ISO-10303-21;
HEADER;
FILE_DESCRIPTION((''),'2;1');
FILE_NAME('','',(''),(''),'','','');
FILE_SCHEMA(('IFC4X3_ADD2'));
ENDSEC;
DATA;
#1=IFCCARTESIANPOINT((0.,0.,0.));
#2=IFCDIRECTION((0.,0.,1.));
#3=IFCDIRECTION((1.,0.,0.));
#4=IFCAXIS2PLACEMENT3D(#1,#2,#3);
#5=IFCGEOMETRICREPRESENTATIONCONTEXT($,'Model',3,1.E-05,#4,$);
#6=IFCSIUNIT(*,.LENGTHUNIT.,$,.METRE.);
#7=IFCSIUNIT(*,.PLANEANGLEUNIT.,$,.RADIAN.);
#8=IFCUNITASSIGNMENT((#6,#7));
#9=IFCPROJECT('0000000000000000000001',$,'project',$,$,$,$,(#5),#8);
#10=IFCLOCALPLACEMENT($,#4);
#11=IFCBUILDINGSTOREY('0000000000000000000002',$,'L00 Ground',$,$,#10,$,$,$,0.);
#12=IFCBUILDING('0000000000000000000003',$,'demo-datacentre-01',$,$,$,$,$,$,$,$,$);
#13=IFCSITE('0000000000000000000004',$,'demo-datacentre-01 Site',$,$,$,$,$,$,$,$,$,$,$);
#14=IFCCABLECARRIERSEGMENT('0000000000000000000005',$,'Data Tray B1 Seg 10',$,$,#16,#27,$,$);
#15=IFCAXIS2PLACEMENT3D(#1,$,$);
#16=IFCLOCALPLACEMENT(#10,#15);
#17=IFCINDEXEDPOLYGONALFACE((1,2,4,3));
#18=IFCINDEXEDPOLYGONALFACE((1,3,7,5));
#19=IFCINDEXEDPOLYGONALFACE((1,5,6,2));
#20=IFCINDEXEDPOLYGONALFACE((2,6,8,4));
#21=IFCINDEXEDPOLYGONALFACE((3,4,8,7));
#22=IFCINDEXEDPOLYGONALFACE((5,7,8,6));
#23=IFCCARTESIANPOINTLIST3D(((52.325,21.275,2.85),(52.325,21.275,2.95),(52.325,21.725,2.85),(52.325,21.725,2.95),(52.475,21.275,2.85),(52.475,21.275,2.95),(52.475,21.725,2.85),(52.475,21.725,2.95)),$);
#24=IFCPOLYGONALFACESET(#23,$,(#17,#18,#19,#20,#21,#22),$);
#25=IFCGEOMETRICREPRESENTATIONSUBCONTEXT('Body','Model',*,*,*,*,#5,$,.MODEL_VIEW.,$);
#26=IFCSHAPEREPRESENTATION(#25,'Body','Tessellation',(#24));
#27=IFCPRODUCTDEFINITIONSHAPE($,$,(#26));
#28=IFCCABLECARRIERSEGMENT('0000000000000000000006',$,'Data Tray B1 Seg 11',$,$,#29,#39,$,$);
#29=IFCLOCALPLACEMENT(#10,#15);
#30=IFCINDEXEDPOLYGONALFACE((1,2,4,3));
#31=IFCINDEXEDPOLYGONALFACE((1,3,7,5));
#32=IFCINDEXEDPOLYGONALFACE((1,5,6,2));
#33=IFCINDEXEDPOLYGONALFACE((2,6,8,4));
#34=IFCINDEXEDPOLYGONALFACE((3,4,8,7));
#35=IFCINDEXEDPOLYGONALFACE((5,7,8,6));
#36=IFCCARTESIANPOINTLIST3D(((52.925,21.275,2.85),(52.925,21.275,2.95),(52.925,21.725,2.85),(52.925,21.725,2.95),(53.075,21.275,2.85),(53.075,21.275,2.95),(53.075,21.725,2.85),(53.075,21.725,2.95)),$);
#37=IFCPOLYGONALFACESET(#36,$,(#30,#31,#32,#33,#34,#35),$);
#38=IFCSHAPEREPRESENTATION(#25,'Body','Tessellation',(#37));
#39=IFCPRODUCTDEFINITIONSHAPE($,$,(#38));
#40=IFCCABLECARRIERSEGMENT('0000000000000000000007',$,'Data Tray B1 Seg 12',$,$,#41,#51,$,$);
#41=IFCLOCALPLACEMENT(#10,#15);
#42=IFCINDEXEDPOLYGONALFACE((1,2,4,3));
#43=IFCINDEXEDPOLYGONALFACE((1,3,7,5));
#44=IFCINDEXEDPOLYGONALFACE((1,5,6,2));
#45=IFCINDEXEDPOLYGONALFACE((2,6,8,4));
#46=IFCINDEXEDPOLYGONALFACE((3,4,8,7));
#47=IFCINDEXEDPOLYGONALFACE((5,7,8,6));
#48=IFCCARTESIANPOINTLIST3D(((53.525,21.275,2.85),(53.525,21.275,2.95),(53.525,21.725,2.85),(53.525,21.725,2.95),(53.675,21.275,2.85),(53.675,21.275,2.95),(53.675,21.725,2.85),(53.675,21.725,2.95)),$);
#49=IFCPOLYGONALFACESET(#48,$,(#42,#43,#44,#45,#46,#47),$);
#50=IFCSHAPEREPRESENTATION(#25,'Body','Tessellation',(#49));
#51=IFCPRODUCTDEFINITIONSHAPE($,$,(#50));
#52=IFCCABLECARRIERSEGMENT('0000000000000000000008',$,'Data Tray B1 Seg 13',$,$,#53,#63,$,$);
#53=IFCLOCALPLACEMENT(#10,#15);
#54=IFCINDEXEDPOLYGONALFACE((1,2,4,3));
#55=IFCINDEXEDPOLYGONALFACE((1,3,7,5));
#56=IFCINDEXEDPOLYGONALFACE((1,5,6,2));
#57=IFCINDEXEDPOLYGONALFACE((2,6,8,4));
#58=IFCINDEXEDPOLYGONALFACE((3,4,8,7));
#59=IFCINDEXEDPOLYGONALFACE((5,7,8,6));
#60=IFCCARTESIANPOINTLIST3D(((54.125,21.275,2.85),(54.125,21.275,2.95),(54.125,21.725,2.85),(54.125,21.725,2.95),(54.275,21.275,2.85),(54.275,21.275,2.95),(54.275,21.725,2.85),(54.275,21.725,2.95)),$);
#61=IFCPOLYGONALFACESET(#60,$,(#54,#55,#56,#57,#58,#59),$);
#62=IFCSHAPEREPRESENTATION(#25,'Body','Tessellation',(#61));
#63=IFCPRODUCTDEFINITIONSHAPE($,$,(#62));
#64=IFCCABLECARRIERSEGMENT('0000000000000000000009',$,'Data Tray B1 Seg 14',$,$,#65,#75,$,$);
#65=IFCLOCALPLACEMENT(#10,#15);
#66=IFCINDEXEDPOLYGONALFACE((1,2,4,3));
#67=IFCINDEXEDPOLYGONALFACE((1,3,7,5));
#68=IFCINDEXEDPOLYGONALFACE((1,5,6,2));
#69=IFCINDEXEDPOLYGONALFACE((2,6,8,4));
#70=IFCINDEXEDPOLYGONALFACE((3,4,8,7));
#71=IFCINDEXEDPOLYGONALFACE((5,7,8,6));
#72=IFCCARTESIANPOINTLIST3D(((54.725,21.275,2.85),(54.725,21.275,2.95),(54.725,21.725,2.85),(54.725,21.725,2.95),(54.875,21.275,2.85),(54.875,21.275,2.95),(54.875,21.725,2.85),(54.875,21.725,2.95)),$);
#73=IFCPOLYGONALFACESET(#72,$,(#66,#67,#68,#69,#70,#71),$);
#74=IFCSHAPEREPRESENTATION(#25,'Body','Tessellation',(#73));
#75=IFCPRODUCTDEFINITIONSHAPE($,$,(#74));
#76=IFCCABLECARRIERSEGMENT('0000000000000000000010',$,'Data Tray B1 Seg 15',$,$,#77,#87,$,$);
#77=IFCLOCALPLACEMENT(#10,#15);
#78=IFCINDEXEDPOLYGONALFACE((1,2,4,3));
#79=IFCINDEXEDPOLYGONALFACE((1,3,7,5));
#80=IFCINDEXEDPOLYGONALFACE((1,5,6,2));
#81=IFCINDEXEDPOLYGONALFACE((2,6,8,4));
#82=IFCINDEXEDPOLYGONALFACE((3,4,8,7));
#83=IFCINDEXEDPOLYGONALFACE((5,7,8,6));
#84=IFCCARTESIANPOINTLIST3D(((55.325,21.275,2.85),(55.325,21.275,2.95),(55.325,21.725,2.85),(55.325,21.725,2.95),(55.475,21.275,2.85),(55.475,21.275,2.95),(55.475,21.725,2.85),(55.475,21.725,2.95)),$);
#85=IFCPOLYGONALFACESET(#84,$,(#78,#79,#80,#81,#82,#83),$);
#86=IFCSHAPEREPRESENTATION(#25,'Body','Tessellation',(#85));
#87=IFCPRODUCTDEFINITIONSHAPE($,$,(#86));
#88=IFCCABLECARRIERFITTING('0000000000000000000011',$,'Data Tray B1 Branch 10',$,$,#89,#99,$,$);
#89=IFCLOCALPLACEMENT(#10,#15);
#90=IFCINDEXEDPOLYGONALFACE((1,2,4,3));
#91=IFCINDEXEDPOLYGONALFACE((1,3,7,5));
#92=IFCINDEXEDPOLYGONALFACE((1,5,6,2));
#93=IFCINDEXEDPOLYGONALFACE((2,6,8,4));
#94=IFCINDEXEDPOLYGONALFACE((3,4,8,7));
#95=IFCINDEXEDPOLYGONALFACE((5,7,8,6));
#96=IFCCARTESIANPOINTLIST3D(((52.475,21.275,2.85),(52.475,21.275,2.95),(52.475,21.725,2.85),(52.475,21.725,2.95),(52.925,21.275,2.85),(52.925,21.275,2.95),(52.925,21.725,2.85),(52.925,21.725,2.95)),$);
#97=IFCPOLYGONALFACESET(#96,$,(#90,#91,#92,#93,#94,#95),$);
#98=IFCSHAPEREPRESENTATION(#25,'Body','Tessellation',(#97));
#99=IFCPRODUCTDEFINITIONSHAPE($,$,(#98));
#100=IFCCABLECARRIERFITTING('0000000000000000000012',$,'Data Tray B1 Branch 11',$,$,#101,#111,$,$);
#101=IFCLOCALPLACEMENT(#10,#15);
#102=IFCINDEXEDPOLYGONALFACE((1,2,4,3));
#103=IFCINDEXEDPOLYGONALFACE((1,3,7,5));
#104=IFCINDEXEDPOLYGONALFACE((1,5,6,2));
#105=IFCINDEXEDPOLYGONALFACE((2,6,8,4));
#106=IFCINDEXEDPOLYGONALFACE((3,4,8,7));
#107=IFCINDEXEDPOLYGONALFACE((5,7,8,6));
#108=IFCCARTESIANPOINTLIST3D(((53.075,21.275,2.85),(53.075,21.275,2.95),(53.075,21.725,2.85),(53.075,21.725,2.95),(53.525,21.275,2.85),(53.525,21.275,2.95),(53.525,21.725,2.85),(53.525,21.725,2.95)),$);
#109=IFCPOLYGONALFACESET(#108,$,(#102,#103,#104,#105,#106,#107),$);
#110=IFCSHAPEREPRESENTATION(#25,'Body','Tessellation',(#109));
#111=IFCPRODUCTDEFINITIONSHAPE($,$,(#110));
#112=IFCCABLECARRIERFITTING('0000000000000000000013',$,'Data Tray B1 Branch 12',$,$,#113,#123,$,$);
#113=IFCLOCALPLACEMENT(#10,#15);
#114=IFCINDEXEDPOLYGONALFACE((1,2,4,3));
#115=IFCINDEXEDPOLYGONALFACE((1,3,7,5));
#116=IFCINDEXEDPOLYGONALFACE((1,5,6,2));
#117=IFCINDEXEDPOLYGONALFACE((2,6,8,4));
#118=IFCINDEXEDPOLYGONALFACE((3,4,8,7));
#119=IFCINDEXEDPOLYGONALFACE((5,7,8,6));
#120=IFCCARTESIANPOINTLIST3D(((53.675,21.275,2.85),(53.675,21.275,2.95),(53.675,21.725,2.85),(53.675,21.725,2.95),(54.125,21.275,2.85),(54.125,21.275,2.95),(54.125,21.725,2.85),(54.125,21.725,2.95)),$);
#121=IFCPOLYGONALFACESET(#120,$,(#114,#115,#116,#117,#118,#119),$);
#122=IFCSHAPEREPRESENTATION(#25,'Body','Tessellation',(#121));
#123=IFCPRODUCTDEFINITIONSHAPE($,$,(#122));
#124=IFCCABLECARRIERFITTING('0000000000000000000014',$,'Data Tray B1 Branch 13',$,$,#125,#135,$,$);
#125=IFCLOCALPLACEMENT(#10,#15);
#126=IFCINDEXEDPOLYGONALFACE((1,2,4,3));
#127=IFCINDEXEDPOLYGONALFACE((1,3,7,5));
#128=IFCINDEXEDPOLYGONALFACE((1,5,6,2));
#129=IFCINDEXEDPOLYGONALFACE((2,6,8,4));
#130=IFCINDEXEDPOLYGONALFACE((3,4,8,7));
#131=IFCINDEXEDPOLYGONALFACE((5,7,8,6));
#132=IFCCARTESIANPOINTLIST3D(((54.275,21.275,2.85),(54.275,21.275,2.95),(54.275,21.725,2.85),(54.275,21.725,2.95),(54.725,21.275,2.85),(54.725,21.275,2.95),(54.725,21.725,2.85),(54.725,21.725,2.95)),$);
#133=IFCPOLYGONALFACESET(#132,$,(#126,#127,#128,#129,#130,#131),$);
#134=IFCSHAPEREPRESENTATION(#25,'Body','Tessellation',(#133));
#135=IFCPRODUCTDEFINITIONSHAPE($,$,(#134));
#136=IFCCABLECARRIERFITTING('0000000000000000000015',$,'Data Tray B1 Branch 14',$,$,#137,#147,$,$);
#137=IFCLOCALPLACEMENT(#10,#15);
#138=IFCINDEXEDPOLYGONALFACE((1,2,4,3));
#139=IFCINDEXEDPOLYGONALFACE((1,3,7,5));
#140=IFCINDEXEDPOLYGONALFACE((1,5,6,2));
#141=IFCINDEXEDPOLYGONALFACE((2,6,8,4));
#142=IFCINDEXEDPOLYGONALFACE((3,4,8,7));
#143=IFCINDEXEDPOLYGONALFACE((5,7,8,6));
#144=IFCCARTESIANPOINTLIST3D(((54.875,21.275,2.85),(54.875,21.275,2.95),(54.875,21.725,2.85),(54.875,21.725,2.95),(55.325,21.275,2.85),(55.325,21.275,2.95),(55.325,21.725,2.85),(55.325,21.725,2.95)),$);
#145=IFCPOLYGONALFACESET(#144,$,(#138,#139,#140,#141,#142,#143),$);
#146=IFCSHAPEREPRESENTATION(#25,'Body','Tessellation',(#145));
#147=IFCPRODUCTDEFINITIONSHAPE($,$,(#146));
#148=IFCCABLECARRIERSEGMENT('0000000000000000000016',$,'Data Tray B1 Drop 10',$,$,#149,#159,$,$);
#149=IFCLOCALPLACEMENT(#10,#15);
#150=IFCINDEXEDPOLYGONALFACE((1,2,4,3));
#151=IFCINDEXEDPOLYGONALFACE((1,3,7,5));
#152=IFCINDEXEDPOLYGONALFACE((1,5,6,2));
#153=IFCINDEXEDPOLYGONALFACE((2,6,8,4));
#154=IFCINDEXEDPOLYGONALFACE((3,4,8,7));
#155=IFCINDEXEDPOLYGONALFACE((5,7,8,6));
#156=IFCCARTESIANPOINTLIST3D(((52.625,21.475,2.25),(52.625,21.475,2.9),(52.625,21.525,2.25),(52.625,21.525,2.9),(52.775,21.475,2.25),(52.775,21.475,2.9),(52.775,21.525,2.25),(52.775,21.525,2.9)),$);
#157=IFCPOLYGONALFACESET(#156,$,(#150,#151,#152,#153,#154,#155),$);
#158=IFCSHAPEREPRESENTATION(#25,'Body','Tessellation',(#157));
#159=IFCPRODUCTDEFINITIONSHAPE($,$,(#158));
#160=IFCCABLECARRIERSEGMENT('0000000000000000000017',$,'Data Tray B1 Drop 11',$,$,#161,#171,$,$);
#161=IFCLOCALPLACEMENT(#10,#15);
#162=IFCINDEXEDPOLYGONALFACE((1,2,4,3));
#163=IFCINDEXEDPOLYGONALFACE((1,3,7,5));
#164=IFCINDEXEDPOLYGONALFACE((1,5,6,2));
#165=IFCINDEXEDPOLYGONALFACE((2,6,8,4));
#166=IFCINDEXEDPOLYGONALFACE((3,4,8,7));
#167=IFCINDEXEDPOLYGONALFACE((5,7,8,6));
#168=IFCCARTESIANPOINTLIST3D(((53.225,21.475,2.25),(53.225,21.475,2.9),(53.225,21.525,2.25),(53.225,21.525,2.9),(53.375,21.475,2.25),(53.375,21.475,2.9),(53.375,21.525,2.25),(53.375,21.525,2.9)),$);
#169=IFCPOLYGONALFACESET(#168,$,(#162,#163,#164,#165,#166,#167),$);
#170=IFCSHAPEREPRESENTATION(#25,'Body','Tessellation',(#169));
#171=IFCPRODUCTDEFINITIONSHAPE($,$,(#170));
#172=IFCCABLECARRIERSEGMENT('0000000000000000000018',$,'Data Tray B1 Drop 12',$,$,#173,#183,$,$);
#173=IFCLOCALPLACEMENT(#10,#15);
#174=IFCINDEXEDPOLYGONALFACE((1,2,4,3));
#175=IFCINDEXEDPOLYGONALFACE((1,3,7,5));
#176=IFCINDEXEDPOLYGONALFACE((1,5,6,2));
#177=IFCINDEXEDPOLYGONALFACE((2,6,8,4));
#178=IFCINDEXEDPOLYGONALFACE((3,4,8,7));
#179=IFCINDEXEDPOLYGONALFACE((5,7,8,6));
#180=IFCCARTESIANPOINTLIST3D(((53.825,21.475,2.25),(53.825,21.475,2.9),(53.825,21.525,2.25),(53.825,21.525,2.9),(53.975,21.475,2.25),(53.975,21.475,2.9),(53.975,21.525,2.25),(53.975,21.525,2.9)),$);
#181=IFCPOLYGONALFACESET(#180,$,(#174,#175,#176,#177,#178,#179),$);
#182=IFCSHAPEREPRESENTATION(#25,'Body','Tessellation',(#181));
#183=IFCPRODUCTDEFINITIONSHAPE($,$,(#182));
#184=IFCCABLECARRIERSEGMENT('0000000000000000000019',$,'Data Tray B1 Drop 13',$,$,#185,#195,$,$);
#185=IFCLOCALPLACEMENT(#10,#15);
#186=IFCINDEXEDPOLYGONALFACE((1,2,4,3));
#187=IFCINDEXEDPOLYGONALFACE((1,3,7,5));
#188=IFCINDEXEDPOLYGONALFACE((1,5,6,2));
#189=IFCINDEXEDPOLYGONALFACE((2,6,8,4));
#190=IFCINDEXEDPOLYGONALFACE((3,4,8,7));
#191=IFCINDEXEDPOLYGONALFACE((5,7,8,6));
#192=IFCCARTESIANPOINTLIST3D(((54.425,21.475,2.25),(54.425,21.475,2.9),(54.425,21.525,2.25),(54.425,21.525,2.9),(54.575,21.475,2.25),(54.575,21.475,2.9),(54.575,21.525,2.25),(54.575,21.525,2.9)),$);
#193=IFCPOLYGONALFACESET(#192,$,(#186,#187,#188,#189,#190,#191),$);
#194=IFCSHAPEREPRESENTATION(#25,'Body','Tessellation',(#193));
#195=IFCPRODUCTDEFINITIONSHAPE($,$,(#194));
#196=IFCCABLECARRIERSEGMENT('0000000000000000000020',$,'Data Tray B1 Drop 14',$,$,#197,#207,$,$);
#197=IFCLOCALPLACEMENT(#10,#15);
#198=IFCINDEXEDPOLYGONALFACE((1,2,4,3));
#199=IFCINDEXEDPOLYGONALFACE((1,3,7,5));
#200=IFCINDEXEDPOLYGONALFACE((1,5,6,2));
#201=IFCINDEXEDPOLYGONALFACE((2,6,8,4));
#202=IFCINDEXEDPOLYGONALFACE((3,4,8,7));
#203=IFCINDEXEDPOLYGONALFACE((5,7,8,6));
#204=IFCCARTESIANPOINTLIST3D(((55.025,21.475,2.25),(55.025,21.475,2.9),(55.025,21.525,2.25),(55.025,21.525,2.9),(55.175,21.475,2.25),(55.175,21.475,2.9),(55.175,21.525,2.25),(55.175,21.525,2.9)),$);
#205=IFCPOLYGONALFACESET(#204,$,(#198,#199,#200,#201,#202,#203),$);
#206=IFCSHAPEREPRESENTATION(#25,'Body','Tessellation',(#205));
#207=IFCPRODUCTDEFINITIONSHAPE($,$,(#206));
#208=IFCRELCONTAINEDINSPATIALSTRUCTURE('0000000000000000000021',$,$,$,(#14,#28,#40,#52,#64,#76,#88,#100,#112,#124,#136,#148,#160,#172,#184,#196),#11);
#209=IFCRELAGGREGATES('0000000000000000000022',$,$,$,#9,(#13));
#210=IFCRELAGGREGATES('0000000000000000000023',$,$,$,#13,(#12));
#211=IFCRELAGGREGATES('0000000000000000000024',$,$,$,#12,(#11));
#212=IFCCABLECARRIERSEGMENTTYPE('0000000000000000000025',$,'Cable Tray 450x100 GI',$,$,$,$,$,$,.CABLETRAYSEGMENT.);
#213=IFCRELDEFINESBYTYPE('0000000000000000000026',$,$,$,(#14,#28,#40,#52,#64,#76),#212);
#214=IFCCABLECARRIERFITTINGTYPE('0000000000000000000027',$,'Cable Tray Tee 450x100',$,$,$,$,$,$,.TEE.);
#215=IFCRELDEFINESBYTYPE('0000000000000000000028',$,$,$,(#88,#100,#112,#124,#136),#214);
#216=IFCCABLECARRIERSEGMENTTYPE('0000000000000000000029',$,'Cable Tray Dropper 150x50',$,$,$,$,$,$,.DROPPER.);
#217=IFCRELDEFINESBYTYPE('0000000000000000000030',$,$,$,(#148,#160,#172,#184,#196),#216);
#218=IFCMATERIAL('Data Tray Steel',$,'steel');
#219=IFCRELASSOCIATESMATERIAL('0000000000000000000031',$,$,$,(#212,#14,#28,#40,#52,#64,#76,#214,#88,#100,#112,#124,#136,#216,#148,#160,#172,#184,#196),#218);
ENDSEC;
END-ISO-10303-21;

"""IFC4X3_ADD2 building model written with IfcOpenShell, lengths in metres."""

from ifc_helpers import new_model, si_unit, frame, origin_with_axes, place, context, subcontext, project, spatial, rectangle, extrude, material, type_object, element, save


model = new_model("IFC4X3_ADD2")

# Units and contexts
model_context = context("Model", 3, precision=1e-05, world=origin_with_axes())
body_context = subcontext(model_context, "Body", "Model", "MODEL_VIEW")
ifc_project = project(units=[si_unit("LENGTHUNIT", "METRE"), si_unit("PLANEANGLEUNIT", "RADIAN")], contexts=[model_context])

# Site, building, storey
site = spatial("IfcSite", under=ifc_project, Name="demo-datacentre-01 Site")
building = spatial("IfcBuilding", under=site, Name="demo-datacentre-01")
storey_placement = place(None, origin_with_axes())
storey = spatial("IfcBuildingStorey", under=building, at=storey_placement, Name="L00 Ground", Elevation=0.0)

# Cable carrier segments
ifc_material_1 = material(Name="Data Tray Steel", Category="steel")
cable_carrier_segment_type_1 = type_object("IfcCableCarrierSegmentType", Name="Cable Tray 450x100 GI", PredefinedType="CABLETRAYSEGMENT", material=ifc_material_1)
for number, where, z_axis, x_axis, name in (
    (1, (52.325, 21.5, 2.9), (1.0, 0.0, 0.0), (0.0, 1.0, 0.0), "Data Tray B1 Seg 10"),
    (2, (52.925, 21.5, 2.9), (1.0, 0.0, 0.0), (0.0, 1.0, 0.0), "Data Tray B1 Seg 11"),
    (3, (53.525, 21.5, 2.9), (1.0, 0.0, 0.0), (0.0, 1.0, 0.0), "Data Tray B1 Seg 12"),
    (4, (54.125, 21.5, 2.9), (1.0, 0.0, 0.0), (0.0, 1.0, 0.0), "Data Tray B1 Seg 13"),
):
    element("IfcCableCarrierSegment", number, at=place(storey_placement, frame(where, z_axis=z_axis, x_axis=x_axis)), inside=storey, type_object=cable_carrier_segment_type_1, material=ifc_material_1, Name=name, context=body_context, shape_type="SweptSolid", body=[
        extrude(rectangle(XDim=0.45, YDim=0.1), origin_with_axes(), (0.0, 0.0, 1.0), 0.15),
    ])
cable_carrier_segment_1_placement = place(storey_placement, frame((54.725, 21.5, 2.9), z_axis=(1.0, 0.0, 0.0), x_axis=(0.0, 1.0, 0.0)))
element("IfcCableCarrierSegment", 5, at=cable_carrier_segment_1_placement, inside=storey, type_object=cable_carrier_segment_type_1, material=ifc_material_1, Name="Data Tray B1 Seg 14", context=body_context, shape_type="SweptSolid", body=[
    extrude(rectangle(XDim=0.45, YDim=0.1), origin_with_axes(), (0.0, 0.0, 1.0), 0.15),
])
cable_carrier_segment_2_placement = place(storey_placement, frame((55.325, 21.5, 2.9), z_axis=(1.0, 0.0, 0.0), x_axis=(0.0, 1.0, 0.0)))
element("IfcCableCarrierSegment", 6, at=cable_carrier_segment_2_placement, inside=storey, type_object=cable_carrier_segment_type_1, material=ifc_material_1, Name="Data Tray B1 Seg 15", context=body_context, shape_type="SweptSolid", body=[
    extrude(rectangle(XDim=0.45, YDim=0.1), origin_with_axes(), (0.0, 0.0, 1.0), 0.15),
])

# Cable carrier fittings
cable_carrier_fitting_type = type_object("IfcCableCarrierFittingType", Name="Cable Tray Tee 450x100", PredefinedType="TEE", material=ifc_material_1)
for number, where, z_axis, x_axis, name in (
    (7, (52.7, 21.5, 2.85), (0.0, 0.0, 1.0), (1.0, 0.0, 0.0), "Data Tray B1 Branch 10"),
    (8, (53.3, 21.5, 2.85), (0.0, 0.0, 1.0), (1.0, 0.0, 0.0), "Data Tray B1 Branch 11"),
    (9, (53.9, 21.5, 2.85), (0.0, 0.0, 1.0), (1.0, 0.0, 0.0), "Data Tray B1 Branch 12"),
    (10, (54.5, 21.5, 2.85), (0.0, 0.0, 1.0), (1.0, 0.0, 0.0), "Data Tray B1 Branch 13"),
    (11, (55.1, 21.5, 2.85), (0.0, 0.0, 1.0), (1.0, 0.0, 0.0), "Data Tray B1 Branch 14"),
):
    element("IfcCableCarrierFitting", number, at=place(storey_placement, frame(where, z_axis=z_axis, x_axis=x_axis)), inside=storey, type_object=cable_carrier_fitting_type, material=ifc_material_1, Name=name, context=body_context, shape_type="SweptSolid", body=[
        extrude(rectangle(XDim=0.45, YDim=0.45), origin_with_axes(), (0.0, 0.0, 1.0), 0.1),
    ])

# Cable carrier segments
cable_carrier_segment_type_2 = type_object("IfcCableCarrierSegmentType", Name="Cable Tray Dropper 150x50", PredefinedType="DROPPER", material=ifc_material_1)
for number, where, z_axis, x_axis, name in (
    (12, (52.7, 21.5, 2.9), (0.0, 0.0, -1.0), (1.0, 0.0, 0.0), "Data Tray B1 Drop 10"),
    (13, (53.3, 21.5, 2.9), (0.0, 0.0, -1.0), (1.0, 0.0, 0.0), "Data Tray B1 Drop 11"),
    (14, (53.9, 21.5, 2.9), (0.0, 0.0, -1.0), (1.0, 0.0, 0.0), "Data Tray B1 Drop 12"),
    (15, (54.5, 21.5, 2.9), (0.0, 0.0, -1.0), (1.0, 0.0, 0.0), "Data Tray B1 Drop 13"),
    (16, (55.1, 21.5, 2.9), (0.0, 0.0, -1.0), (1.0, 0.0, 0.0), "Data Tray B1 Drop 14"),
):
    element("IfcCableCarrierSegment", number, at=place(storey_placement, frame(where, z_axis=z_axis, x_axis=x_axis)), inside=storey, type_object=cable_carrier_segment_type_2, material=ifc_material_1, Name=name, context=body_context, shape_type="SweptSolid", body=[
        extrude(rectangle(XDim=0.15, YDim=0.05), origin_with_axes(), (0.0, 0.0, 1.0), 0.65),
    ])

save(model, "model.ifc")
